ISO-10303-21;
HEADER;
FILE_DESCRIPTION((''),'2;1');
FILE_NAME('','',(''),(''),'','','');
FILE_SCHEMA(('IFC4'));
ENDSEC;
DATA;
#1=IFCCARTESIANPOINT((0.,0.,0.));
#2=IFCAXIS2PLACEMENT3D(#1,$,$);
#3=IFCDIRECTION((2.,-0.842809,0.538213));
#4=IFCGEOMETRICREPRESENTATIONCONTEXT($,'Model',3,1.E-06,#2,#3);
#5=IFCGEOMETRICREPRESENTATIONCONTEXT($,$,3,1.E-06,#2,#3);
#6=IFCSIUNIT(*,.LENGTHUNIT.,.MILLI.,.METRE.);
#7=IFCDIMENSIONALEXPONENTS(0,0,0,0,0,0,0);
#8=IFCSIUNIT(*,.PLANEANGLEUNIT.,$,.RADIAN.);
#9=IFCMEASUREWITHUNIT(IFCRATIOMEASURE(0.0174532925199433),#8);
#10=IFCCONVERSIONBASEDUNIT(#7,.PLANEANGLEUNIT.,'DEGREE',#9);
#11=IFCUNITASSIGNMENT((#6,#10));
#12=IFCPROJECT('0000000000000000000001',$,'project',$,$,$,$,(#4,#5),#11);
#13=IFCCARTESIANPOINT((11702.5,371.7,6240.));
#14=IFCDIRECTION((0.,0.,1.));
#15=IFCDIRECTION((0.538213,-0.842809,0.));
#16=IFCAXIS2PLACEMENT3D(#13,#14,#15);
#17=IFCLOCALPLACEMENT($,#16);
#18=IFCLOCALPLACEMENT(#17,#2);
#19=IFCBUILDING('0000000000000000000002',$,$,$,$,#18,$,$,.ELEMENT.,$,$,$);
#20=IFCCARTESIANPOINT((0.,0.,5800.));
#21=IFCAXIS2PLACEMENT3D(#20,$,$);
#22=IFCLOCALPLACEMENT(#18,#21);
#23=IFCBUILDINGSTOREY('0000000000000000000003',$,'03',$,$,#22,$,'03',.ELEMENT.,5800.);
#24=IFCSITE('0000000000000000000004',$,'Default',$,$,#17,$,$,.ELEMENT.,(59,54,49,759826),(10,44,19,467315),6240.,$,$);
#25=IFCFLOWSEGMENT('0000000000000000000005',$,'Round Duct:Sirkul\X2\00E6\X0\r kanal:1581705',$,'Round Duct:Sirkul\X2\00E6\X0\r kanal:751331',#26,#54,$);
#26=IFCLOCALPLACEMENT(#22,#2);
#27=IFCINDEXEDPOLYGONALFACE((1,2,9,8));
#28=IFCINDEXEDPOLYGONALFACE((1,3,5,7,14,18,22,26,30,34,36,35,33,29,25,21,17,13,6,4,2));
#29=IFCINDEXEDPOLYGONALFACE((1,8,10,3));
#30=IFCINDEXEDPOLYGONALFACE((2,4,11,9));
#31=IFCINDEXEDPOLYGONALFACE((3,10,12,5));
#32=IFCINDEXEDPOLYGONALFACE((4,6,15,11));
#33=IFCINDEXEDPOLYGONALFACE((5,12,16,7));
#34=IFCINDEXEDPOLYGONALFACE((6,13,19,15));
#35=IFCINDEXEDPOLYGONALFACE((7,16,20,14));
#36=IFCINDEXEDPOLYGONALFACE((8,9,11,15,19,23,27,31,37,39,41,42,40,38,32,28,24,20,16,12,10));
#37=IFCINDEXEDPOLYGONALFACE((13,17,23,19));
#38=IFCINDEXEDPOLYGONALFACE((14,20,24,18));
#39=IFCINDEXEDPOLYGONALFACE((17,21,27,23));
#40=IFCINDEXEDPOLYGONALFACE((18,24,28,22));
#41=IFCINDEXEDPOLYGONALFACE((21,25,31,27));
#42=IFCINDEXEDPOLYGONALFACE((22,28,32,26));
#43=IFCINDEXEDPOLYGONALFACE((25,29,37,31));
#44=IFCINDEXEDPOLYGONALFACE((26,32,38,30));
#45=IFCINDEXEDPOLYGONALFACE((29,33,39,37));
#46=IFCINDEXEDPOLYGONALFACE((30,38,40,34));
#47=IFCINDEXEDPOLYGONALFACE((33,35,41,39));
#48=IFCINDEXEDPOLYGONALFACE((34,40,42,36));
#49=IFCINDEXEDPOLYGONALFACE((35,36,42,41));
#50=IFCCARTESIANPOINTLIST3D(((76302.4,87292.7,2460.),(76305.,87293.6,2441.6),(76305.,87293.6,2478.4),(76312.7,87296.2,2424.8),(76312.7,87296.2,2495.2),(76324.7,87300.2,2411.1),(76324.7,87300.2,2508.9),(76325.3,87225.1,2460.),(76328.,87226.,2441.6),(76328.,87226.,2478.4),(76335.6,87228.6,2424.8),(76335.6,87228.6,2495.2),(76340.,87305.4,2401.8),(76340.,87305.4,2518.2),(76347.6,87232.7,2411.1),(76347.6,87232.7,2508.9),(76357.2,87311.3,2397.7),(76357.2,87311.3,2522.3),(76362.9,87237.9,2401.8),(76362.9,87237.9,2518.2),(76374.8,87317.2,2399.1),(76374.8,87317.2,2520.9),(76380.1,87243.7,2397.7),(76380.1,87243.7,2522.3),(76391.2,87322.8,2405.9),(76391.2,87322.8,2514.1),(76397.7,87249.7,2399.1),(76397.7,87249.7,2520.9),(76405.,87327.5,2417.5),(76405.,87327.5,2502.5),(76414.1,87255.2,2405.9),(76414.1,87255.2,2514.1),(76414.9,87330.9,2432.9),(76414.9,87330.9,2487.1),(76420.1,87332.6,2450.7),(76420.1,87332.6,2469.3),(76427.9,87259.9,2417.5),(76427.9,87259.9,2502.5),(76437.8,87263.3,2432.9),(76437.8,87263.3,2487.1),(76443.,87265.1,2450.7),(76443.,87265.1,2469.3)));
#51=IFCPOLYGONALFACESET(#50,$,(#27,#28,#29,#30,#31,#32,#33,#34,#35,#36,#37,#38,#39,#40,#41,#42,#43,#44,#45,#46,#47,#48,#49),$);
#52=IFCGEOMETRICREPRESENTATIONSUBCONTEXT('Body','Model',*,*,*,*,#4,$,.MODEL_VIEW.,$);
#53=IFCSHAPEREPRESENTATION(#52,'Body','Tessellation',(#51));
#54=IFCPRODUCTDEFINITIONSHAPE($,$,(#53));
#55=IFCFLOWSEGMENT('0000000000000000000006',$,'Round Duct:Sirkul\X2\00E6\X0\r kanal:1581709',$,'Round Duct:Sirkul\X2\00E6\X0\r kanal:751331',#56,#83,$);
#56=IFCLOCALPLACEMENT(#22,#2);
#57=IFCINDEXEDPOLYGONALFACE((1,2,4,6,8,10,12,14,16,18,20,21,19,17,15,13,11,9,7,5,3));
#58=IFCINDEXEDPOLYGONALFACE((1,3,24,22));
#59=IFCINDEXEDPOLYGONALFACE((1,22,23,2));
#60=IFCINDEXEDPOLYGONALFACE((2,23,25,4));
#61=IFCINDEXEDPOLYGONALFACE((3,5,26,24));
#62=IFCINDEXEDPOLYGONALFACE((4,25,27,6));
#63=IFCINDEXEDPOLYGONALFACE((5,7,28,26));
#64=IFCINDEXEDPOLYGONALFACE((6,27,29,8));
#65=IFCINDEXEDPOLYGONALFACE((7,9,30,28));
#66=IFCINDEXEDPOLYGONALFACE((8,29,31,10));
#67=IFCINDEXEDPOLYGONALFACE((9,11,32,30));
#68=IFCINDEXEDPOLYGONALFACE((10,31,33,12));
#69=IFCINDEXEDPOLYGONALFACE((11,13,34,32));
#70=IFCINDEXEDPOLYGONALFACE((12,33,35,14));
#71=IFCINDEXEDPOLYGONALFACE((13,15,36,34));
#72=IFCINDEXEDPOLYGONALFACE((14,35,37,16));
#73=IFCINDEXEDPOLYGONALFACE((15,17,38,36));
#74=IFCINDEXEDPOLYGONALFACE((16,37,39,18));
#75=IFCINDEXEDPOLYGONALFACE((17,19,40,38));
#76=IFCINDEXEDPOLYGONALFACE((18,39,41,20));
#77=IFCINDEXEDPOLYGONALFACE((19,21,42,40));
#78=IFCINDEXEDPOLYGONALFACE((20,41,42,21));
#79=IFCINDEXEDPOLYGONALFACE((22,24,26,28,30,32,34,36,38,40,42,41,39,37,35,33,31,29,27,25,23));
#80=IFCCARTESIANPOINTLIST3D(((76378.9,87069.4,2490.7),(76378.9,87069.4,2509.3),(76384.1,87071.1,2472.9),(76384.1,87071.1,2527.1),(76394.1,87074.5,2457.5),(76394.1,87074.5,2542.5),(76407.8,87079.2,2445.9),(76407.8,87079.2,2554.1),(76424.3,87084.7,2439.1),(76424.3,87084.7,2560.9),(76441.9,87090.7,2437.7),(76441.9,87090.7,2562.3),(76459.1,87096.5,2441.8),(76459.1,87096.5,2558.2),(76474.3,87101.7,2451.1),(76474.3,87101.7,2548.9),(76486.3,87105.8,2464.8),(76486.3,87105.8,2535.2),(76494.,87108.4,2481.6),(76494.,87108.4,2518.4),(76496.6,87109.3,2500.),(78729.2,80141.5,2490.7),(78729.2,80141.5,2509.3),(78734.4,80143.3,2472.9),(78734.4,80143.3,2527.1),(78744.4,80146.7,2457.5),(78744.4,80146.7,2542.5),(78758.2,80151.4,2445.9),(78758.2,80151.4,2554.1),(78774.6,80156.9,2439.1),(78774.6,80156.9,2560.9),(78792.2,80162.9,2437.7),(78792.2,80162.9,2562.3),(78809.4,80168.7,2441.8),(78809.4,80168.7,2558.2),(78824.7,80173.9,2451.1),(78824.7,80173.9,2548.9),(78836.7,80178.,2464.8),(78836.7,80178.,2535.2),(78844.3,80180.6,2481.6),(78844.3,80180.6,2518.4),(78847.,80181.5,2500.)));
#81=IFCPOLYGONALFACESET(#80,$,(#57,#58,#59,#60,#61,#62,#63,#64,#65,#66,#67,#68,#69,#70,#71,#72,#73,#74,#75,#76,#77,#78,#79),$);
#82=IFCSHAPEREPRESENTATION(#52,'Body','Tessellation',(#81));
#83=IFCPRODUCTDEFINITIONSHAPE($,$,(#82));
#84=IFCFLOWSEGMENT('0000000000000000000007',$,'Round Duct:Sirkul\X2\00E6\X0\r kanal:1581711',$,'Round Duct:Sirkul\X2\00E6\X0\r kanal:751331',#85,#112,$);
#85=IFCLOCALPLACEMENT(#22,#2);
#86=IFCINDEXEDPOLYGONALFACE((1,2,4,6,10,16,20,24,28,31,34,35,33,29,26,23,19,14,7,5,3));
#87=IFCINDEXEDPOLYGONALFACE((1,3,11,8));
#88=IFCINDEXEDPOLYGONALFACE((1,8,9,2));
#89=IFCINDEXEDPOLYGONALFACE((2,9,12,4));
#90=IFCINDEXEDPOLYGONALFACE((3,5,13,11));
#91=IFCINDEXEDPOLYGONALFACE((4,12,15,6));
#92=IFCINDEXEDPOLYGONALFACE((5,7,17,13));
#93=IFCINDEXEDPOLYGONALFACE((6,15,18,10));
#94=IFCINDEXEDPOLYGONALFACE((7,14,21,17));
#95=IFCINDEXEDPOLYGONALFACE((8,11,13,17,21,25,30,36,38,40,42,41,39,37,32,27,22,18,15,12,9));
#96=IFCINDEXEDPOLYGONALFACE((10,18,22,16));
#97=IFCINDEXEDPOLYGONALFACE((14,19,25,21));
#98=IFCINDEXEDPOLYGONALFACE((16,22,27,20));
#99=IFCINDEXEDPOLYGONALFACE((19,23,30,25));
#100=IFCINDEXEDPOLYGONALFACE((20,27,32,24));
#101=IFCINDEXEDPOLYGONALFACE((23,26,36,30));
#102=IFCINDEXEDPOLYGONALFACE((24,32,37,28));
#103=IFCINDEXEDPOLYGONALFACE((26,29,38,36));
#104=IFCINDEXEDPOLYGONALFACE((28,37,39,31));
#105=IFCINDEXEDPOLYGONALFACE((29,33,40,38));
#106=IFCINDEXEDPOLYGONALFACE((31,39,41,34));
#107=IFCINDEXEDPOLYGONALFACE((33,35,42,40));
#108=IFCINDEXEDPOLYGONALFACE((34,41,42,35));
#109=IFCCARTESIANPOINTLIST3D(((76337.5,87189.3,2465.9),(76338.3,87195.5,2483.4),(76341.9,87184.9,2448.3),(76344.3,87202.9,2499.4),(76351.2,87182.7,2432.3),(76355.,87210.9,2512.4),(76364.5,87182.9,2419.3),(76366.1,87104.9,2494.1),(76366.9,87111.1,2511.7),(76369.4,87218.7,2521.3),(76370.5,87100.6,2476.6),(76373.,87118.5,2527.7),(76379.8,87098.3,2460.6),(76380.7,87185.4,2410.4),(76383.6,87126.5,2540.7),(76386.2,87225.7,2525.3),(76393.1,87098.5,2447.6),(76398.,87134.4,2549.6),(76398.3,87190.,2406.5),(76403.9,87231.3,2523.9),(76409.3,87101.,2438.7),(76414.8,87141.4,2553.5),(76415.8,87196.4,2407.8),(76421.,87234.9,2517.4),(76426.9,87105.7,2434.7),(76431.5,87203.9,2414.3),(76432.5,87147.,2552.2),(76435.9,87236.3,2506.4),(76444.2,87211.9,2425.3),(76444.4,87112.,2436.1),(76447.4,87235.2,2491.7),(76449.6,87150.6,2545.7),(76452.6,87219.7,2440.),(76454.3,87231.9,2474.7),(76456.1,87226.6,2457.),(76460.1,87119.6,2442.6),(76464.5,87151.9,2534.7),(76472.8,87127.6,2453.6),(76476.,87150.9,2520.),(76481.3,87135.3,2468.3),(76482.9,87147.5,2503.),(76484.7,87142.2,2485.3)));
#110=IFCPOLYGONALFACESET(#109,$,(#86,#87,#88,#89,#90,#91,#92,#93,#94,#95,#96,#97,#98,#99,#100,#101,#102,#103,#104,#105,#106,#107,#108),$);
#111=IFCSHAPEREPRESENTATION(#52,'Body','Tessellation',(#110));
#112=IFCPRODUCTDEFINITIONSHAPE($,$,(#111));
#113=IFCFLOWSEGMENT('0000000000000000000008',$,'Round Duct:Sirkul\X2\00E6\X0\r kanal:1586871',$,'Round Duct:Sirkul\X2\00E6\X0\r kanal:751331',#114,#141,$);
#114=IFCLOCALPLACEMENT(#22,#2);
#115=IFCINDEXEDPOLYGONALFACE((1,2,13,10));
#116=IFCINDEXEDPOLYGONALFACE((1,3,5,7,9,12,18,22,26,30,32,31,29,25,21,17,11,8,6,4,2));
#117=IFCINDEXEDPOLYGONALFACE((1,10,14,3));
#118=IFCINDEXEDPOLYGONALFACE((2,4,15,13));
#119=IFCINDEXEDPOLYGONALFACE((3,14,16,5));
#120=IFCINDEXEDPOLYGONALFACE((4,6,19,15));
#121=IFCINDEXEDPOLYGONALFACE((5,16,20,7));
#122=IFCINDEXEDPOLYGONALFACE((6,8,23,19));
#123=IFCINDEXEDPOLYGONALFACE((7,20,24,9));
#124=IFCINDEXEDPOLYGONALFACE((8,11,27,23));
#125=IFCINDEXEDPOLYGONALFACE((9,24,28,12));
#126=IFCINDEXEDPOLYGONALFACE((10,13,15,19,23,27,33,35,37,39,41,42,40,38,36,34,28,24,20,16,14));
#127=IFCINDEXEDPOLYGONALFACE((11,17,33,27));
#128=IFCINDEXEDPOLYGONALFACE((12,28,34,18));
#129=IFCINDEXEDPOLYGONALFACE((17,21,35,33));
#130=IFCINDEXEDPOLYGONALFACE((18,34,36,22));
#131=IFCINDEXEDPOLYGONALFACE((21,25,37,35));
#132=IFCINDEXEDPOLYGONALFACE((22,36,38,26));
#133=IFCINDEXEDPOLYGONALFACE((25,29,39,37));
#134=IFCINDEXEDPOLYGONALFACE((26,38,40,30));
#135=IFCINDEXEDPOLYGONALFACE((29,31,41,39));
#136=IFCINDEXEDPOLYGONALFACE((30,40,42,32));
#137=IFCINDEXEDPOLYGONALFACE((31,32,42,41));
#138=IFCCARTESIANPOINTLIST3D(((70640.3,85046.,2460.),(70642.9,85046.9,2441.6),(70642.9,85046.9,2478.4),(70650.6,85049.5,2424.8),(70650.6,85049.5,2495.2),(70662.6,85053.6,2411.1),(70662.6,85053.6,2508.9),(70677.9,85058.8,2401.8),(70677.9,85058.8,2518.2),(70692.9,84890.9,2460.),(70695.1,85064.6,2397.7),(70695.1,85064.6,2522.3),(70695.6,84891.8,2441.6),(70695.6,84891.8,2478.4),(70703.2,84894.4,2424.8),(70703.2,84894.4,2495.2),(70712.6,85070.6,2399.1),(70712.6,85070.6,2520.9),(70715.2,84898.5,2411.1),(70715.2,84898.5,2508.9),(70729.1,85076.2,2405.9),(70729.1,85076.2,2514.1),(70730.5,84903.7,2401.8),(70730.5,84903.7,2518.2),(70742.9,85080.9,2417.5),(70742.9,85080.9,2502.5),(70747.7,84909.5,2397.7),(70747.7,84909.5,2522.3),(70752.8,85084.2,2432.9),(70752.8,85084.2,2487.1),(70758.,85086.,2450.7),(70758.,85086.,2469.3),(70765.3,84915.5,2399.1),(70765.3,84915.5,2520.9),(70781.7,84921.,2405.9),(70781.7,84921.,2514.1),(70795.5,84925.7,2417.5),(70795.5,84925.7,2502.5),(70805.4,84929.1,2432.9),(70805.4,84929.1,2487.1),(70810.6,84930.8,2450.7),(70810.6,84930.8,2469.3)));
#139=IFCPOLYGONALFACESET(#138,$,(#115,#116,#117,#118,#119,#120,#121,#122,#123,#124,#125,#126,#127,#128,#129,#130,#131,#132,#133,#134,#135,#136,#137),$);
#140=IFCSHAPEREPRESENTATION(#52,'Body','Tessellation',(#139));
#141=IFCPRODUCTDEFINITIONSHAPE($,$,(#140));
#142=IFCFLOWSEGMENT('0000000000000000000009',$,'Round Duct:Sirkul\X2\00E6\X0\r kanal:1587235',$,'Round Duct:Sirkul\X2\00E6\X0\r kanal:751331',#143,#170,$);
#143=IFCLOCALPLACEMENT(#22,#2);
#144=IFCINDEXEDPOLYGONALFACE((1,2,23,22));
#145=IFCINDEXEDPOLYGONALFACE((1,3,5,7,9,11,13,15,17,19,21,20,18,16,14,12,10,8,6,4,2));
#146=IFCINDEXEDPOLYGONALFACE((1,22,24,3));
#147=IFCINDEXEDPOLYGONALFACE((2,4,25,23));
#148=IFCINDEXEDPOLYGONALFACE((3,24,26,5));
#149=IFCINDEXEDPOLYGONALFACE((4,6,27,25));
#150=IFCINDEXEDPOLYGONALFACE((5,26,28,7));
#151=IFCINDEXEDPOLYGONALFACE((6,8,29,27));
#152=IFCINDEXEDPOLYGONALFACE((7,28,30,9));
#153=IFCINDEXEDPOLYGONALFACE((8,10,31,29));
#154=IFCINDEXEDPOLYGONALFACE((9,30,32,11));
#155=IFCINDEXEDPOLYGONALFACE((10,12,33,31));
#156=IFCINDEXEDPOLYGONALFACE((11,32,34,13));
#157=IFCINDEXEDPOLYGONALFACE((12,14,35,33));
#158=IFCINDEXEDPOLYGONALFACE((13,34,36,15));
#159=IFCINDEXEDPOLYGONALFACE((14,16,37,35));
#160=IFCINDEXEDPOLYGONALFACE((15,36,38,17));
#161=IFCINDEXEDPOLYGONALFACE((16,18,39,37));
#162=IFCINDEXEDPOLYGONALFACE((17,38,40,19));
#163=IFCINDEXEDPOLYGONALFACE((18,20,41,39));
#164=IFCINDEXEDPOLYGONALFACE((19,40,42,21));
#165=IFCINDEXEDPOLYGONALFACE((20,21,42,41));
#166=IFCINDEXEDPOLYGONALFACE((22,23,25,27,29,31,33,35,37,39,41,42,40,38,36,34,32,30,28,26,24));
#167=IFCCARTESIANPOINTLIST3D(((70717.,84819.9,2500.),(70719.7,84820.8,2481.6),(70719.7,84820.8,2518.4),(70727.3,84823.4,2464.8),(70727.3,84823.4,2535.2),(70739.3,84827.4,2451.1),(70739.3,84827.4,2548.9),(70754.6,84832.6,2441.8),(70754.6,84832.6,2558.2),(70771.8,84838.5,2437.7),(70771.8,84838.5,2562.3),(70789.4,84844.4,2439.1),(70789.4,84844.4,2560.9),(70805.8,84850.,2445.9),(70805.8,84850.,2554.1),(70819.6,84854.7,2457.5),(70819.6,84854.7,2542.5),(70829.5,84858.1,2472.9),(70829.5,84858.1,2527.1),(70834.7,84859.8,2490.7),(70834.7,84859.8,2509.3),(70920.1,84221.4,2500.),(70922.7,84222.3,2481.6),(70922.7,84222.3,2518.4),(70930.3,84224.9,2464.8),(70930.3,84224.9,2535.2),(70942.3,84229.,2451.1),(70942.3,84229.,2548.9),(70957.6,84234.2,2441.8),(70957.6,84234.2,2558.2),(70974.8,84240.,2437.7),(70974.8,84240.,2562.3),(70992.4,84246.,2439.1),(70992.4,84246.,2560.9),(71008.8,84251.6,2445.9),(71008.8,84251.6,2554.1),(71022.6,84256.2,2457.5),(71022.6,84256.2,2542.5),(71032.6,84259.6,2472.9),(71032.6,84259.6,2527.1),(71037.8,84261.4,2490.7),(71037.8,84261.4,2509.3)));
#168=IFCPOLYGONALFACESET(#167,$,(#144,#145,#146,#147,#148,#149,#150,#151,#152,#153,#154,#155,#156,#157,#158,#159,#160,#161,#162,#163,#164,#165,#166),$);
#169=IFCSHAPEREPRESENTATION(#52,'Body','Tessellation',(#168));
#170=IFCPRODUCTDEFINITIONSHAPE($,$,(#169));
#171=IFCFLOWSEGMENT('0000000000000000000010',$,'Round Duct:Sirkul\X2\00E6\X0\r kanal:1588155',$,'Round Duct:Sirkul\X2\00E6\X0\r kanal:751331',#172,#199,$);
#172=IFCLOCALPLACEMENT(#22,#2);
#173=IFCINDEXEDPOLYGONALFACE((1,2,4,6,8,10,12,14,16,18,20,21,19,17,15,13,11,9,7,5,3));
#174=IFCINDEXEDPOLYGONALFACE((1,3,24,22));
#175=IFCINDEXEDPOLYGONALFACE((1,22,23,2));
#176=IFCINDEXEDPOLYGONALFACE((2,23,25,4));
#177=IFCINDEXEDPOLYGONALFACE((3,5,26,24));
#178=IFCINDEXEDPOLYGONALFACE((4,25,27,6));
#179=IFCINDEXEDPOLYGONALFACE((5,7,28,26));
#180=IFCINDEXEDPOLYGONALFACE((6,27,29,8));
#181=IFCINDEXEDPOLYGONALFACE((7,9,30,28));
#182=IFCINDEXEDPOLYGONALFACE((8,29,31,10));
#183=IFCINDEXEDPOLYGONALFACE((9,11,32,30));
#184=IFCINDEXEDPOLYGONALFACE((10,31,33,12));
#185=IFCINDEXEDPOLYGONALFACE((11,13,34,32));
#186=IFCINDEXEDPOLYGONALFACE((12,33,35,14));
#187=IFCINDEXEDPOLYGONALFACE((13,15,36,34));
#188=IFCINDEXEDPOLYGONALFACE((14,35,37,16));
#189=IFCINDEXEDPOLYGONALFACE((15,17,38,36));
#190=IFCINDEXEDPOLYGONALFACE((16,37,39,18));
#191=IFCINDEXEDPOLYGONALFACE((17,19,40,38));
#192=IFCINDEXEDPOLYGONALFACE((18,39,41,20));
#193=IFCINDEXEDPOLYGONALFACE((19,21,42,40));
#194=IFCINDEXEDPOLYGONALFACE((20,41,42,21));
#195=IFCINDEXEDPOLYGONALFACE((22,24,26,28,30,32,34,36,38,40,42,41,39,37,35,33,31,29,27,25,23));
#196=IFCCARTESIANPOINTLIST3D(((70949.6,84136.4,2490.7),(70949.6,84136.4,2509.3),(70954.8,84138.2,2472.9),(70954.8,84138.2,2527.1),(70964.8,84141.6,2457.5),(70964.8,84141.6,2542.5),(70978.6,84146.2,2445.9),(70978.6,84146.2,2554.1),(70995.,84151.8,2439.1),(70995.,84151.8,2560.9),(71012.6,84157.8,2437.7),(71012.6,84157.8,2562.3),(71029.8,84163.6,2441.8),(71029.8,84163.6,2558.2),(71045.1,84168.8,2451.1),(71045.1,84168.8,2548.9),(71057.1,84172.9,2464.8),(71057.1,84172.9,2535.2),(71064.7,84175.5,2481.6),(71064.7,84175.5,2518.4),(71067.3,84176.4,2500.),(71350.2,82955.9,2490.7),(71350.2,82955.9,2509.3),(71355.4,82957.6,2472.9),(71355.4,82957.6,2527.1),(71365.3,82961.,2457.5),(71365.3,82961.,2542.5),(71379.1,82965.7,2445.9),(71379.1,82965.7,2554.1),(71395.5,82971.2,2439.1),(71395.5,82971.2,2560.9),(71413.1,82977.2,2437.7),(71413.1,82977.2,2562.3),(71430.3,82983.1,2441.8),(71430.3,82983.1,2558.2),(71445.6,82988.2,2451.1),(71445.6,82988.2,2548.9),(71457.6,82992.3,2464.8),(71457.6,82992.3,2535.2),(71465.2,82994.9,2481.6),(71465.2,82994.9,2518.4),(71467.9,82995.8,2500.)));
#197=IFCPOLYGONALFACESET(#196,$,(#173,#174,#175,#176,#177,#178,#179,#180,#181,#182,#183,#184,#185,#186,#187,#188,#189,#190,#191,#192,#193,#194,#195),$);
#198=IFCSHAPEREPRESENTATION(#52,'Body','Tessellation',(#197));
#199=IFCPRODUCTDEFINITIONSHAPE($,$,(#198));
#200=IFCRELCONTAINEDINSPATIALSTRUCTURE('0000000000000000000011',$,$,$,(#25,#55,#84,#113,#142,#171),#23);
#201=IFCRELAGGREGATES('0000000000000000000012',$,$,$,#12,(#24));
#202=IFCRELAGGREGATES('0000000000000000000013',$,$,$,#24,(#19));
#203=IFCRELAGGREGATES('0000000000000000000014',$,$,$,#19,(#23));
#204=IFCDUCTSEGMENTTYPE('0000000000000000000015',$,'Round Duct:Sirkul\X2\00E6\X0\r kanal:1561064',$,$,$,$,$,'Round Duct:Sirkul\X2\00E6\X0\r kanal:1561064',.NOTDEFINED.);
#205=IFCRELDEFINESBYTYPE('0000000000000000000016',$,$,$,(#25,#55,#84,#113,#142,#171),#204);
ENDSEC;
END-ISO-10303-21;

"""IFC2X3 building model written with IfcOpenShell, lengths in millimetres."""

from ifc_helpers import new_model, entity, si_unit, converted_unit, direction, frame, frame_2d, origin, origin_2d_with_axis, place, context, subcontext, project, spatial, circle, extrude, type_object, element, save


model = new_model("IFC2X3")

# Units and contexts
model_context = context("Model", 3, precision=1e-06, world=origin(), true_north=direction((2.0, -0.842809, 0.538213)))
context_of_model = context(None, 3, precision=1e-06, world=origin(), true_north=direction((2.0, -0.842809, 0.538213)))
body_context = subcontext(model_context, "Body", "Model", "MODEL_VIEW")
ifc_project = project(units=[si_unit("LENGTHUNIT", "METRE", prefix="MILLI"), converted_unit("PLANEANGLEUNIT", "DEGREE", entity("IfcRatioMeasure", 0.0174532925199433), si_unit("PLANEANGLEUNIT", "RADIAN"), dimensions=[0, 0, 0, 0, 0, 0, 0])], contexts=[model_context, context_of_model])

# Site, building, storey
site_placement = place(None, frame((11702.5, 371.7, 6240.0), z_axis=(0.0, 0.0, 1.0), x_axis=(0.538213, -0.842809, 0.0)))
site = spatial("IfcSite", under=ifc_project, at=site_placement, Name="Default", CompositionType="ELEMENT", RefLatitude=(59, 54, 49, 759826), RefLongitude=(10, 44, 19, 467315), RefElevation=6240.0)
building_placement = place(site_placement, origin())
building = spatial("IfcBuilding", under=site, at=building_placement, CompositionType="ELEMENT")
storey_placement = place(building_placement, frame((0.0, 0.0, 5800.0)))
storey = spatial("IfcBuildingStorey", under=building, at=storey_placement, Name="03", LongName="03", CompositionType="ELEMENT", Elevation=5800.0)

# Flow segments
duct_segment_type = type_object("IfcDuctSegmentType", Name="Round Duct:Sirkulær kanal:1561064", ElementType="Round Duct:Sirkulær kanal:1561064", PredefinedType="NOTDEFINED")
flow_segment_1_placement = place(storey_placement, origin())
element("IfcFlowSegment", 1, at=flow_segment_1_placement, inside=storey, type_object=duct_segment_type, Name="Round Duct:Sirkulær kanal:1581705", ObjectType="Round Duct:Sirkulær kanal:751331", context=body_context, shape_type="SweptSolid", body=[
    extrude(circle(Radius=62.5, at=origin_2d_with_axis()), frame((76361.6, 87312.8, 2460.0), z_axis=(0.321302, -0.946977, 0.0), x_axis=(-0.946977, -0.321302, 0.0)), (0.0, 0.0, 1.0), 71.3),
])
flow_segment_2_placement = place(storey_placement, origin())
element("IfcFlowSegment", 2, at=flow_segment_2_placement, inside=storey, type_object=duct_segment_type, Name="Round Duct:Sirkulær kanal:1581709", ObjectType="Round Duct:Sirkulær kanal:751331", context=body_context, shape_type="SweptSolid", body=[
    extrude(circle(Radius=62.5, at=frame_2d((0.0, 0.0), x_axis=(1.0, 0.0))), frame((76437.4, 87089.2, 2500.0), z_axis=(0.321274, -0.946986, 0.0), x_axis=(0.946986, 0.321274, 0.0)), (0.0, 0.0, 1.0), 7315.6),
])
flow_segment_3_placement = place(storey_placement, origin())
element("IfcFlowSegment", 3, at=flow_segment_3_placement, inside=storey, type_object=duct_segment_type, Name="Round Duct:Sirkulær kanal:1581711", ObjectType="Round Duct:Sirkulær kanal:751331", context=body_context, shape_type="SweptSolid", body=[
    extrude(circle(Radius=62.5, at=frame_2d((0.0, 0.0), x_axis=(1.0, 0.0))), frame((76396.7, 87209.4, 2465.9), z_axis=(0.306214, -0.902596, 0.302579), x_axis=(-0.946986, -0.321274, 0.0)), (0.0, 0.0, 1.0), 93.5),
])
flow_segment_4_placement = place(storey_placement, origin())
element("IfcFlowSegment", 4, at=flow_segment_4_placement, inside=storey, type_object=duct_segment_type, Name="Round Duct:Sirkulær kanal:1586871", ObjectType="Round Duct:Sirkulær kanal:751331", context=body_context, shape_type="SweptSolid", body=[
    extrude(circle(Radius=62.5, at=frame_2d((0.0, 0.0), x_axis=(1.0, 0.0))), frame((70699.5, 85066.1, 2460.0), z_axis=(0.321315, -0.946972, 0.0), x_axis=(-0.946972, -0.321315, 0.0)), (0.0, 0.0, 1.0), 163.8),
])
flow_segment_5_placement = place(storey_placement, origin())
element("IfcFlowSegment", 5, at=flow_segment_5_placement, inside=storey, type_object=duct_segment_type, Name="Round Duct:Sirkulær kanal:1587235", ObjectType="Round Duct:Sirkulær kanal:751331", context=body_context, shape_type="SweptSolid", body=[
    extrude(circle(Radius=62.5, at=frame_2d((0.0, 0.0), x_axis=(1.0, 0.0))), frame((70979.2, 84241.5, 2500.0), z_axis=(-0.321274, 0.946986, 0.0), x_axis=(-0.946986, -0.321274, 0.0)), (0.0, 0.0, 1.0), 632.0),
])
flow_segment_6_placement = place(storey_placement, origin())
element("IfcFlowSegment", 6, at=flow_segment_6_placement, inside=storey, type_object=duct_segment_type, Name="Round Duct:Sirkulær kanal:1588155", ObjectType="Round Duct:Sirkulær kanal:751331", context=body_context, shape_type="SweptSolid", body=[
    extrude(circle(Radius=62.5, at=frame_2d((0.0, 0.0), x_axis=(1.0, 0.0))), frame((71008.2, 84156.3, 2500.0), z_axis=(0.321274, -0.946986, 0.0), x_axis=(0.946986, 0.321274, 0.0)), (0.0, 0.0, 1.0), 1246.7),
])

save(model, "model.ifc")
